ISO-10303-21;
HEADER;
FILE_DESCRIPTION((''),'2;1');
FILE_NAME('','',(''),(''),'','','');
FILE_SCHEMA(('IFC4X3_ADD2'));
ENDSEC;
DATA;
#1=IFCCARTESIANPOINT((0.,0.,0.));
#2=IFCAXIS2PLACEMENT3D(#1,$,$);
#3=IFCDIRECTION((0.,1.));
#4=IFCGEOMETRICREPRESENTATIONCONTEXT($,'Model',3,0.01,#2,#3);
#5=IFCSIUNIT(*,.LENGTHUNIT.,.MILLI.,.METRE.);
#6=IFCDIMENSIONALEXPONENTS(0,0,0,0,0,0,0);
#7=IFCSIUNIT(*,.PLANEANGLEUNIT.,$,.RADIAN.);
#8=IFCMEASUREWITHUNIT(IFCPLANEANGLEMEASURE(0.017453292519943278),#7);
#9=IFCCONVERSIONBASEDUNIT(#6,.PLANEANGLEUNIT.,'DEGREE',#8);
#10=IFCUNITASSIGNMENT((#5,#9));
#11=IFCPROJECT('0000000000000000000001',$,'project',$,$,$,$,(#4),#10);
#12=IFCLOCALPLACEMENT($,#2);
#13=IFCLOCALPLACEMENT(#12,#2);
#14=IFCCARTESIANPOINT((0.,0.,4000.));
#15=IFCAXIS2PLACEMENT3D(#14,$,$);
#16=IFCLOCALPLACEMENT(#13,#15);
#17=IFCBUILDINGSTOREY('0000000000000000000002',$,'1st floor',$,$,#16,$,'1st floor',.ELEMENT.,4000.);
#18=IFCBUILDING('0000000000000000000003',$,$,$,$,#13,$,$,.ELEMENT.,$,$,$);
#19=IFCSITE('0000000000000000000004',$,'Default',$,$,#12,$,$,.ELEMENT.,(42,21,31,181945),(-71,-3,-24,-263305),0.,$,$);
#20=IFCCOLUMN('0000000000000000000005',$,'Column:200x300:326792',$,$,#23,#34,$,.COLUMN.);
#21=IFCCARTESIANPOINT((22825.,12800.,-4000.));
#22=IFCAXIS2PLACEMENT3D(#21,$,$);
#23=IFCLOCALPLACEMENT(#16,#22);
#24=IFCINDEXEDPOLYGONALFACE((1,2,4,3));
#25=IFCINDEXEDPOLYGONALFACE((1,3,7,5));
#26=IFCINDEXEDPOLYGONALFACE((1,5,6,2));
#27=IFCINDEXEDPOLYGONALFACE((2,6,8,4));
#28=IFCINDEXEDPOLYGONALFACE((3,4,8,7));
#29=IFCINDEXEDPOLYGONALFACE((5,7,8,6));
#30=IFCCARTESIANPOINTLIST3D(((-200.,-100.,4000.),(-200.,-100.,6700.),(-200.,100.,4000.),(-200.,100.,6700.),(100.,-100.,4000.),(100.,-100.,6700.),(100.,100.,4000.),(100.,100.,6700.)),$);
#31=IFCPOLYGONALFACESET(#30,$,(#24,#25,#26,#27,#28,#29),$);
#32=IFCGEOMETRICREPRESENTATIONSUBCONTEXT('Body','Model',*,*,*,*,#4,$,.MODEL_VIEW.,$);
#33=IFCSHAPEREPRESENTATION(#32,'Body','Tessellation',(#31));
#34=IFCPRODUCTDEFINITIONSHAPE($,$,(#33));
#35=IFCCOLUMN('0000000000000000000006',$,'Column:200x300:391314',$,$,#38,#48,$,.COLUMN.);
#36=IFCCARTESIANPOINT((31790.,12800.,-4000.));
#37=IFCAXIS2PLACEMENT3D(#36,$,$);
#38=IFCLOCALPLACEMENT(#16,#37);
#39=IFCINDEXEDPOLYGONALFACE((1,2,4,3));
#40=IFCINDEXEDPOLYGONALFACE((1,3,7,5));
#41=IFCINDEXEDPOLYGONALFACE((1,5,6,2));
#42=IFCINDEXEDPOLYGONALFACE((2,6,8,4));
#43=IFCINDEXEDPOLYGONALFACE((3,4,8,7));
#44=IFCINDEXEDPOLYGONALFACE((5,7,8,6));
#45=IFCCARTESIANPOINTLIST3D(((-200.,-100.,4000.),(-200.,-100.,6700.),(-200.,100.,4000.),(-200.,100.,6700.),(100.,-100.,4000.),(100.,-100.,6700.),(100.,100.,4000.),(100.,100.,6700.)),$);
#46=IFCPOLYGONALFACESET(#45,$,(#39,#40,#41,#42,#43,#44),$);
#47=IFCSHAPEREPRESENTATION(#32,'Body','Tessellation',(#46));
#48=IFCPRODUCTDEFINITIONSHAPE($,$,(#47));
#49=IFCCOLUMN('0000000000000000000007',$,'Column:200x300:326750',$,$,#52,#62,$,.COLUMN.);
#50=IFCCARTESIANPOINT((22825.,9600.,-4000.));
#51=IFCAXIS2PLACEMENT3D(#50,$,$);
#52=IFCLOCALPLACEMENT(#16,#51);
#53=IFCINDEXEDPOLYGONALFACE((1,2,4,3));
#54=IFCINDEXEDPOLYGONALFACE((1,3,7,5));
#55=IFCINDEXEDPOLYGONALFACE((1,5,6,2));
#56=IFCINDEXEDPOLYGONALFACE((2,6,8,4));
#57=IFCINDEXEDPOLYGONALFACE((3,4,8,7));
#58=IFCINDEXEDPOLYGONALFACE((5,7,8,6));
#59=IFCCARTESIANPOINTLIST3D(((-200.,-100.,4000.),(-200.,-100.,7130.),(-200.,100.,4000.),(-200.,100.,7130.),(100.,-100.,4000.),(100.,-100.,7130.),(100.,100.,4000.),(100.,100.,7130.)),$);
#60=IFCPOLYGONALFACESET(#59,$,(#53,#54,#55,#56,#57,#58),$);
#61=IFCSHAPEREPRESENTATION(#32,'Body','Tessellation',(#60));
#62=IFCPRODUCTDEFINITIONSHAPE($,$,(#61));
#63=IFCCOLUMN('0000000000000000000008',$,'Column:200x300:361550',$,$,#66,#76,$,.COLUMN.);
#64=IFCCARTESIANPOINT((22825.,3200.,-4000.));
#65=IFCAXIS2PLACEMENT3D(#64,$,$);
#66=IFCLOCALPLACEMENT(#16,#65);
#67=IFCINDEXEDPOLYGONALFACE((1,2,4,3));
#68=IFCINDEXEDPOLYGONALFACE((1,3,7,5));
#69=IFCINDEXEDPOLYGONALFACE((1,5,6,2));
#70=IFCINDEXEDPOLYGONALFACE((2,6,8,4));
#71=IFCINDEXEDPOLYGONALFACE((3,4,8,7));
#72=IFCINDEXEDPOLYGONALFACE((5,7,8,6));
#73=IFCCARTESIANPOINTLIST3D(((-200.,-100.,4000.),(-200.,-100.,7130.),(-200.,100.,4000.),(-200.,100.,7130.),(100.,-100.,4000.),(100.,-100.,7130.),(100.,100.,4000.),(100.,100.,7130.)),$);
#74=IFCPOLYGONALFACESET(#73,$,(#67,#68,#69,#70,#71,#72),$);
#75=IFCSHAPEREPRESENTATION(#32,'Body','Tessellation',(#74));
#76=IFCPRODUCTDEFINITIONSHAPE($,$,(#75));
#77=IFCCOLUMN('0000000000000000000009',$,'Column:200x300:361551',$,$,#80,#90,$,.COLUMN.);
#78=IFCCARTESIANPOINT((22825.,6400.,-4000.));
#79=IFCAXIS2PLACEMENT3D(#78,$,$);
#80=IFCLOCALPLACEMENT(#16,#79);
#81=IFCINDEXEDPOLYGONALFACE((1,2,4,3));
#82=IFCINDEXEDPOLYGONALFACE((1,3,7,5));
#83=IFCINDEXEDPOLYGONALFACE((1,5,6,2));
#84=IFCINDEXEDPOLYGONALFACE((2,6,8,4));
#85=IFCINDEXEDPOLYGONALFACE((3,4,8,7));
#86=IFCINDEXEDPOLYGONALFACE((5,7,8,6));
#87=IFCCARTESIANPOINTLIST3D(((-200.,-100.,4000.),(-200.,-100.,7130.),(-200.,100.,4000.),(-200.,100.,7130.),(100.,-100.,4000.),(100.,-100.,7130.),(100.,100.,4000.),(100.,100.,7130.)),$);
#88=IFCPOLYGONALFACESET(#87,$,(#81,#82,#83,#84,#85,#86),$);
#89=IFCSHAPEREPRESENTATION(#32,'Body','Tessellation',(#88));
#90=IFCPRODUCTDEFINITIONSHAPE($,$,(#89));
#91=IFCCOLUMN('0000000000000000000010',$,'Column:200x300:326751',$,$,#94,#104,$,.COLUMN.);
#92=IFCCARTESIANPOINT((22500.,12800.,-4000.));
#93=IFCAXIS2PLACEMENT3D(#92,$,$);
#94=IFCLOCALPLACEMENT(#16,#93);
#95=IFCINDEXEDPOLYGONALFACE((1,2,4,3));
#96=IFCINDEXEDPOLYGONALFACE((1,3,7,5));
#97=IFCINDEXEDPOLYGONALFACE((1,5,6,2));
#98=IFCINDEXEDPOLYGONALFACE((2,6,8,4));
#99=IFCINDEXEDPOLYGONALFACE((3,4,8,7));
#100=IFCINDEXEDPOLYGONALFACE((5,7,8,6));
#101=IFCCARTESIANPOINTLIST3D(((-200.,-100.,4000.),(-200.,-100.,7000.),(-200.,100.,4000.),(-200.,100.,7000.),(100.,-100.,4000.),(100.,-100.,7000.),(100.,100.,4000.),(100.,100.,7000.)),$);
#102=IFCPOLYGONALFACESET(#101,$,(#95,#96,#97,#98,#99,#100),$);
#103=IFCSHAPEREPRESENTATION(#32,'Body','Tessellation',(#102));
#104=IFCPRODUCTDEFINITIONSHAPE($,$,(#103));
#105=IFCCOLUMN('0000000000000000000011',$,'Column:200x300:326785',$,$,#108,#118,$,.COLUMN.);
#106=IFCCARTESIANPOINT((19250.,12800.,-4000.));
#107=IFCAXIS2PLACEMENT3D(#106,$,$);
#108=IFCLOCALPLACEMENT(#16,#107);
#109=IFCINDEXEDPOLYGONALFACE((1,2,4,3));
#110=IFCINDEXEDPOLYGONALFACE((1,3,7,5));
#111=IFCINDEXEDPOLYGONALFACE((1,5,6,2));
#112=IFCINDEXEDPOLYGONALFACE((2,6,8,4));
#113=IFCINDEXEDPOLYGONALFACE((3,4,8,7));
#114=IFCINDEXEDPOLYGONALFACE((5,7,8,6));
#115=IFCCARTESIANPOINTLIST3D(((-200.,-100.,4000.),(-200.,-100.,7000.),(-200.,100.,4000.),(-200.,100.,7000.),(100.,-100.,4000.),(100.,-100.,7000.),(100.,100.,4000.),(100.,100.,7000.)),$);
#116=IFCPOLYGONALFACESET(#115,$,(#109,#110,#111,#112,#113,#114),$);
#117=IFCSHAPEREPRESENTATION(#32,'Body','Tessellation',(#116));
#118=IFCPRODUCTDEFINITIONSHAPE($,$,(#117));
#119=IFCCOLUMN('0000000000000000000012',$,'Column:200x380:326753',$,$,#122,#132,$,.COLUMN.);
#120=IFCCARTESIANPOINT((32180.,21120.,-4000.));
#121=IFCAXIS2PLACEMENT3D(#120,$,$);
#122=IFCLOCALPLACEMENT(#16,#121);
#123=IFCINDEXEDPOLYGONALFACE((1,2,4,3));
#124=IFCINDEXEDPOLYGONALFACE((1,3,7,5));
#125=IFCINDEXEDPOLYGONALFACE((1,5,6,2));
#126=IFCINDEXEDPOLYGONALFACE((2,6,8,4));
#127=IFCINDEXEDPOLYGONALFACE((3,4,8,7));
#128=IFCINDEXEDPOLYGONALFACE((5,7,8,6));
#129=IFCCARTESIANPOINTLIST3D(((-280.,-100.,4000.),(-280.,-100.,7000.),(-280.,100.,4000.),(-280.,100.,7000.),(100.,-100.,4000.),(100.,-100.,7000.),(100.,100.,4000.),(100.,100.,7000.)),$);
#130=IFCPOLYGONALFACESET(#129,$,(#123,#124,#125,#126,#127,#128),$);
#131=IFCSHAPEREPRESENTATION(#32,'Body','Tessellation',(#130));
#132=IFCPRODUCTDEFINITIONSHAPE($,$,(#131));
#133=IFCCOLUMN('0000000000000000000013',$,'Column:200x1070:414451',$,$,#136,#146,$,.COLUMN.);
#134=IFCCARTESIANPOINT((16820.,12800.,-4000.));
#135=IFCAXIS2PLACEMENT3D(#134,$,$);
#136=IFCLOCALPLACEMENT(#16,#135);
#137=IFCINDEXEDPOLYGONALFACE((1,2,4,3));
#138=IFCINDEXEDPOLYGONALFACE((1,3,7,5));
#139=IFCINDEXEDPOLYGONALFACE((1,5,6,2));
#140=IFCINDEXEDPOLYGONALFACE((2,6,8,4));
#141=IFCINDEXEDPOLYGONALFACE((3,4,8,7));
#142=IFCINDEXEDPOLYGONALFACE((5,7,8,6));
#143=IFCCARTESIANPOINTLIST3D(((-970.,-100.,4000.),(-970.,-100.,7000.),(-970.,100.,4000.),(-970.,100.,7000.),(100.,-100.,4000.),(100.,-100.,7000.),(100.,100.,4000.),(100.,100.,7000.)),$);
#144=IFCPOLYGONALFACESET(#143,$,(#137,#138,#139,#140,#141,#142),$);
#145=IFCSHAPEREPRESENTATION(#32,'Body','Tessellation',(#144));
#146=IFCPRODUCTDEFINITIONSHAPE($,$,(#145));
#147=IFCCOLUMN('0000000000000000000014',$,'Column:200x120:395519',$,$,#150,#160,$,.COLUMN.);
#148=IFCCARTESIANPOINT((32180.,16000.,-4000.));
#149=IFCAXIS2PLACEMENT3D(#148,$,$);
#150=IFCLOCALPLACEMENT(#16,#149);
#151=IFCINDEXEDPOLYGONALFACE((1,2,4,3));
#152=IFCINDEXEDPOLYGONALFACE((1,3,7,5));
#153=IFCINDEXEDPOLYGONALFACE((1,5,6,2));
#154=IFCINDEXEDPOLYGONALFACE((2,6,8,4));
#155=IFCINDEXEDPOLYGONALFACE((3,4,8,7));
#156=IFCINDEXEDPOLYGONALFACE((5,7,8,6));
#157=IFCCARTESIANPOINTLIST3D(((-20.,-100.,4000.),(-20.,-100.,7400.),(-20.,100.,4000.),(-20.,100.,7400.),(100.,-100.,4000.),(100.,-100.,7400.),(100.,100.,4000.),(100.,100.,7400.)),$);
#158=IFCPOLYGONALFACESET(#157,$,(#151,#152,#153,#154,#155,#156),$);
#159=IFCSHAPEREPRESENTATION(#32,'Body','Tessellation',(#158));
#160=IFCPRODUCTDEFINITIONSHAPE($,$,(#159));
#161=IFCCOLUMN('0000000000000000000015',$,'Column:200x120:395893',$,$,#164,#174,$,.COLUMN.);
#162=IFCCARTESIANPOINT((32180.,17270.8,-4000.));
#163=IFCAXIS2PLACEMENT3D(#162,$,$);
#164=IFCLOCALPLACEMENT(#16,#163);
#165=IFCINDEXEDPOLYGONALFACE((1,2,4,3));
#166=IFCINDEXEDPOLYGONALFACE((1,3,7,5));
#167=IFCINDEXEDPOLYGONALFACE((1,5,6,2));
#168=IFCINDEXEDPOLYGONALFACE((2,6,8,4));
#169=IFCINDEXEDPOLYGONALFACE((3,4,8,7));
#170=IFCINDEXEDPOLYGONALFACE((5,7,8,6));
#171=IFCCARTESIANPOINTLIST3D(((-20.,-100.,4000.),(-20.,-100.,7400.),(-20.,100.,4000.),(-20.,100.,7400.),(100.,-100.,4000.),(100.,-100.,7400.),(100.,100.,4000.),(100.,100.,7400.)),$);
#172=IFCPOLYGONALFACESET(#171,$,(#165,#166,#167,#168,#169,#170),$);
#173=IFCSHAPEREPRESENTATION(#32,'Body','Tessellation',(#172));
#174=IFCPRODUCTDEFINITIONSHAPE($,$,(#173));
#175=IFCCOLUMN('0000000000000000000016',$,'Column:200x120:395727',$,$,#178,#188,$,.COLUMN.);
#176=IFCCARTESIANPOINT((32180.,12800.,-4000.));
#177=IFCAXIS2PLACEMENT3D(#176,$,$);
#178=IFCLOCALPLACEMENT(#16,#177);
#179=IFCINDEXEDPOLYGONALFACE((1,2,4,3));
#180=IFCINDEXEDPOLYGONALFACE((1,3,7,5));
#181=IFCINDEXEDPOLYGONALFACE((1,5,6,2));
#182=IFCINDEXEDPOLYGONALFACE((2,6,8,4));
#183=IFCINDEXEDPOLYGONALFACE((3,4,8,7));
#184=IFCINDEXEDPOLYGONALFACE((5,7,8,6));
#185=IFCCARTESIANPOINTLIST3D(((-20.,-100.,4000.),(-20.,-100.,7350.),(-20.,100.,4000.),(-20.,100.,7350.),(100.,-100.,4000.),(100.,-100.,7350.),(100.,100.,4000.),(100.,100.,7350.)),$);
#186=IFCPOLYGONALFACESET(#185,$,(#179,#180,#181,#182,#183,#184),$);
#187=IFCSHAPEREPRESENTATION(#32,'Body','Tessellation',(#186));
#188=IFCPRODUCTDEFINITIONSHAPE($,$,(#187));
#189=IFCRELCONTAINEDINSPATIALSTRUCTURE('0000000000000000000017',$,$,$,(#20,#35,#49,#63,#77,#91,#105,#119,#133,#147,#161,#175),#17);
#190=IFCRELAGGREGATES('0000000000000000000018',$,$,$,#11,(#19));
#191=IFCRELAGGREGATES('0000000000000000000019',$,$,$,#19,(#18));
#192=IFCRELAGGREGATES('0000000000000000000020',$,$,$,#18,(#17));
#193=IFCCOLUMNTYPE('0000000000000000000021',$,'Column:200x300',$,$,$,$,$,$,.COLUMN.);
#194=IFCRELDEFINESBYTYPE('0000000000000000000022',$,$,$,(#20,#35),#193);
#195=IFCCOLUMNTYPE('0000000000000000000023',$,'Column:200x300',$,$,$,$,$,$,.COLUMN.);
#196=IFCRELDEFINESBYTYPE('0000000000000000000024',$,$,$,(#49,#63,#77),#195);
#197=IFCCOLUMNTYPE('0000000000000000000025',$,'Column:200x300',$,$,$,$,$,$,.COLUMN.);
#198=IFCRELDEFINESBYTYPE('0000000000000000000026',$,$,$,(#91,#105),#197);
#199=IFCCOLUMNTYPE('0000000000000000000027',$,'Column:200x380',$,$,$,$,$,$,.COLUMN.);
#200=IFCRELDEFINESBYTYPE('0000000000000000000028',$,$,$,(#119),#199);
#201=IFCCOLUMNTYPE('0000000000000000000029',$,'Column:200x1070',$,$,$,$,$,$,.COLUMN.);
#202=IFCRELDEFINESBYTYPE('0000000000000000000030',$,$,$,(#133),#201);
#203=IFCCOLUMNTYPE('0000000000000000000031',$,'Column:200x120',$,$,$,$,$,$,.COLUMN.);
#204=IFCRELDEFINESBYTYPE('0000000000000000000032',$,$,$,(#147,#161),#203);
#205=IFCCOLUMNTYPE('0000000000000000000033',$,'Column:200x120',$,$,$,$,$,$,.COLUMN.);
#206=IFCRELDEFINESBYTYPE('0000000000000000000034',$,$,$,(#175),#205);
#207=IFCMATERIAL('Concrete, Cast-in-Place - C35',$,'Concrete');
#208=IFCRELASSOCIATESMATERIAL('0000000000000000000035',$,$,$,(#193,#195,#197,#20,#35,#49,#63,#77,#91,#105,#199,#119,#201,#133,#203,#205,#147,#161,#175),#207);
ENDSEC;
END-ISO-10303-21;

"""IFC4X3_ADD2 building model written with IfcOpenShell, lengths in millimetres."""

from ifc_helpers import new_model, entity, si_unit, converted_unit, direction, frame, origin, origin_2d_with_axis, place, context, subcontext, project, spatial, rectangle, extrude, source, transform, mapped, material, material_profile, profile_set, profile_usage, type_object, type_shapes, element, save


model = new_model("IFC4X3_ADD2")

# Units and contexts
model_context = context("Model", 3, precision=0.01, world=origin(), true_north=direction((0.0, 1.0)))
body_context = subcontext(model_context, "Body", "Model", "MODEL_VIEW")
ifc_project = project(units=[si_unit("LENGTHUNIT", "METRE", prefix="MILLI"), converted_unit("PLANEANGLEUNIT", "DEGREE", entity("IfcPlaneAngleMeasure", 0.017453292519943278), si_unit("PLANEANGLEUNIT", "RADIAN"), dimensions=[0, 0, 0, 0, 0, 0, 0])], contexts=[model_context])

# Site, building, storey
site_placement = place(None, origin())
site = spatial("IfcSite", under=ifc_project, at=site_placement, Name="Default", CompositionType="ELEMENT", RefLatitude=(42, 21, 31, 181945), RefLongitude=(-71, -3, -24, -263305), RefElevation=0.0)
building_placement = place(site_placement, origin())
building = spatial("IfcBuilding", under=site, at=building_placement, CompositionType="ELEMENT")
storey_placement = place(building_placement, frame((0.0, 0.0, 4000.0)))
storey = spatial("IfcBuildingStorey", under=building, at=storey_placement, Name="1st floor", LongName="1st floor", CompositionType="ELEMENT", Elevation=4000.0)

# Columns
ifc_material_1 = material(Name="Concrete, Cast-in-Place - C35", Category="Concrete")
ifc_material_profile_1 = material_profile(ifc_material_1, rectangle(XDim=300.0, YDim=200.0, at=origin_2d_with_axis()), Name="200x300")
ifc_profile_set_1 = profile_set([ifc_material_profile_1], Name="200x300")
ifc_profile_usage_1 = profile_usage(ifc_profile_set_1)
column_type_1 = type_object("IfcColumnType", Name="Column:200x300", PredefinedType="COLUMN", material=ifc_profile_set_1)
shared_shape_1 = source(origin(), body_context, "Body", "SweptSolid", [
    extrude(rectangle(XDim=300.0, YDim=200.0, at=origin_2d_with_axis()), frame((-50.0, 0.0, 4000.0), z_axis=(0.0, 0.0, 1.0), x_axis=(-1.0, 0.0, 0.0)), (0.0, 0.0, 1.0), 2700.0),
])
type_shapes(column_type_1, [shared_shape_1])
for number, where, name in (
    (1, (22825.0, 12800.0, -4000.0), "Column:200x300:326792"),
    (2, (31790.0, 12800.0, -4000.0), "Column:200x300:391314"),
):
    element("IfcColumn", number, at=place(storey_placement, frame(where)), inside=storey, type_object=column_type_1, material=ifc_profile_usage_1, Name=name, PredefinedType="COLUMN", context=body_context, shape_type="MappedRepresentation", body=[
        mapped(shared_shape_1, transform((0.0, 0.0, 0.0), scale=1.0)),
    ])
column_type_2 = type_object("IfcColumnType", Name="Column:200x300", PredefinedType="COLUMN", material=ifc_profile_set_1)
shared_shape_2 = source(origin(), body_context, "Body", "SweptSolid", [
    extrude(rectangle(XDim=300.0, YDim=200.0, at=origin_2d_with_axis()), frame((-50.0, 0.0, 4000.0), z_axis=(0.0, 0.0, 1.0), x_axis=(-1.0, 0.0, 0.0)), (0.0, 0.0, 1.0), 3130.0),
])
type_shapes(column_type_2, [shared_shape_2])
for number, where, name in (
    (3, (22825.0, 9600.0, -4000.0), "Column:200x300:326750"),
    (4, (22825.0, 3200.0, -4000.0), "Column:200x300:361550"),
    (5, (22825.0, 6400.0, -4000.0), "Column:200x300:361551"),
):
    element("IfcColumn", number, at=place(storey_placement, frame(where)), inside=storey, type_object=column_type_2, material=ifc_profile_usage_1, Name=name, PredefinedType="COLUMN", context=body_context, shape_type="MappedRepresentation", body=[
        mapped(shared_shape_2, transform((0.0, 0.0, 0.0), scale=1.0)),
    ])
column_type_3 = type_object("IfcColumnType", Name="Column:200x300", PredefinedType="COLUMN", material=ifc_profile_set_1)
shared_shape_3 = source(origin(), body_context, "Body", "SweptSolid", [
    extrude(rectangle(XDim=300.0, YDim=200.0, at=origin_2d_with_axis()), frame((-50.0, 0.0, 4000.0), z_axis=(0.0, 0.0, 1.0), x_axis=(-1.0, 0.0, 0.0)), (0.0, 0.0, 1.0), 3000.0),
])
type_shapes(column_type_3, [shared_shape_3])
for number, where, name in (
    (6, (22500.0, 12800.0, -4000.0), "Column:200x300:326751"),
    (7, (19250.0, 12800.0, -4000.0), "Column:200x300:326785"),
):
    element("IfcColumn", number, at=place(storey_placement, frame(where)), inside=storey, type_object=column_type_3, material=ifc_profile_usage_1, Name=name, PredefinedType="COLUMN", context=body_context, shape_type="MappedRepresentation", body=[
        mapped(shared_shape_3, transform((0.0, 0.0, 0.0), scale=1.0)),
    ])
ifc_material_profile_2 = material_profile(ifc_material_1, rectangle(XDim=380.0, YDim=200.0, at=origin_2d_with_axis()), Name="200x380")
ifc_profile_set_2 = profile_set([ifc_material_profile_2], Name="200x380")
ifc_profile_usage_2 = profile_usage(ifc_profile_set_2)
column_type_4 = type_object("IfcColumnType", Name="Column:200x380", PredefinedType="COLUMN", material=ifc_profile_set_2)
shared_shape_4 = source(origin(), body_context, "Body", "SweptSolid", [
    extrude(rectangle(XDim=380.0, YDim=200.0, at=origin_2d_with_axis()), frame((-90.0, 0.0, 4000.0), z_axis=(0.0, 0.0, 1.0), x_axis=(-1.0, 0.0, 0.0)), (0.0, 0.0, 1.0), 3000.0),
])
type_shapes(column_type_4, [shared_shape_4])
column_1_placement = place(storey_placement, frame((32180.0, 21120.0, -4000.0)))
element("IfcColumn", 8, at=column_1_placement, inside=storey, type_object=column_type_4, material=ifc_profile_usage_2, Name="Column:200x380:326753", PredefinedType="COLUMN", context=body_context, shape_type="MappedRepresentation", body=[
    mapped(shared_shape_4, transform((0.0, 0.0, 0.0), scale=1.0)),
])
ifc_material_profile_3 = material_profile(ifc_material_1, rectangle(XDim=1070.0, YDim=200.0, at=origin_2d_with_axis()), Name="200x1070")
ifc_profile_set_3 = profile_set([ifc_material_profile_3], Name="200x1070")
ifc_profile_usage_3 = profile_usage(ifc_profile_set_3)
column_type_5 = type_object("IfcColumnType", Name="Column:200x1070", PredefinedType="COLUMN", material=ifc_profile_set_3)
shared_shape_5 = source(origin(), body_context, "Body", "SweptSolid", [
    extrude(rectangle(XDim=1070.0, YDim=200.0, at=origin_2d_with_axis()), frame((-435.0, 0.0, 4000.0), z_axis=(0.0, 0.0, 1.0), x_axis=(-1.0, 0.0, 0.0)), (0.0, 0.0, 1.0), 3000.0),
])
type_shapes(column_type_5, [shared_shape_5])
column_2_placement = place(storey_placement, frame((16820.0, 12800.0, -4000.0)))
element("IfcColumn", 9, at=column_2_placement, inside=storey, type_object=column_type_5, material=ifc_profile_usage_3, Name="Column:200x1070:414451", PredefinedType="COLUMN", context=body_context, shape_type="MappedRepresentation", body=[
    mapped(shared_shape_5, transform((0.0, 0.0, 0.0), scale=1.0)),
])
ifc_material_profile_4 = material_profile(ifc_material_1, rectangle(XDim=120.0, YDim=200.0, at=origin_2d_with_axis()), Name="200x120")
ifc_profile_set_4 = profile_set([ifc_material_profile_4], Name="200x120")
ifc_profile_usage_4 = profile_usage(ifc_profile_set_4)
column_type_6 = type_object("IfcColumnType", Name="Column:200x120", PredefinedType="COLUMN", material=ifc_profile_set_4)
shared_shape_6 = source(origin(), body_context, "Body", "SweptSolid", [
    extrude(rectangle(XDim=120.0, YDim=200.0, at=origin_2d_with_axis()), frame((40.0, 0.0, 4000.0), z_axis=(0.0, 0.0, 1.0), x_axis=(-1.0, 0.0, 0.0)), (0.0, 0.0, 1.0), 3400.0),
])
type_shapes(column_type_6, [shared_shape_6])
for number, where, name in (
    (10, (32180.0, 16000.0, -4000.0), "Column:200x120:395519"),
    (11, (32180.0, 17270.8, -4000.0), "Column:200x120:395893"),
):
    element("IfcColumn", number, at=place(storey_placement, frame(where)), inside=storey, type_object=column_type_6, material=ifc_profile_usage_4, Name=name, PredefinedType="COLUMN", context=body_context, shape_type="MappedRepresentation", body=[
        mapped(shared_shape_6, transform((0.0, 0.0, 0.0), scale=1.0)),
    ])
column_type_7 = type_object("IfcColumnType", Name="Column:200x120", PredefinedType="COLUMN", material=ifc_profile_set_4)
shared_shape_7 = source(origin(), body_context, "Body", "SweptSolid", [
    extrude(rectangle(XDim=120.0, YDim=200.0, at=origin_2d_with_axis()), frame((40.0, 0.0, 4000.0), z_axis=(0.0, 0.0, 1.0), x_axis=(-1.0, 0.0, 0.0)), (0.0, 0.0, 1.0), 3350.0),
])
type_shapes(column_type_7, [shared_shape_7])
column_3_placement = place(storey_placement, frame((32180.0, 12800.0, -4000.0)))
element("IfcColumn", 12, at=column_3_placement, inside=storey, type_object=column_type_7, material=ifc_profile_usage_4, Name="Column:200x120:395727", PredefinedType="COLUMN", context=body_context, shape_type="MappedRepresentation", body=[
    mapped(shared_shape_7, transform((0.0, 0.0, 0.0), scale=1.0)),
])

save(model, "model.ifc")
